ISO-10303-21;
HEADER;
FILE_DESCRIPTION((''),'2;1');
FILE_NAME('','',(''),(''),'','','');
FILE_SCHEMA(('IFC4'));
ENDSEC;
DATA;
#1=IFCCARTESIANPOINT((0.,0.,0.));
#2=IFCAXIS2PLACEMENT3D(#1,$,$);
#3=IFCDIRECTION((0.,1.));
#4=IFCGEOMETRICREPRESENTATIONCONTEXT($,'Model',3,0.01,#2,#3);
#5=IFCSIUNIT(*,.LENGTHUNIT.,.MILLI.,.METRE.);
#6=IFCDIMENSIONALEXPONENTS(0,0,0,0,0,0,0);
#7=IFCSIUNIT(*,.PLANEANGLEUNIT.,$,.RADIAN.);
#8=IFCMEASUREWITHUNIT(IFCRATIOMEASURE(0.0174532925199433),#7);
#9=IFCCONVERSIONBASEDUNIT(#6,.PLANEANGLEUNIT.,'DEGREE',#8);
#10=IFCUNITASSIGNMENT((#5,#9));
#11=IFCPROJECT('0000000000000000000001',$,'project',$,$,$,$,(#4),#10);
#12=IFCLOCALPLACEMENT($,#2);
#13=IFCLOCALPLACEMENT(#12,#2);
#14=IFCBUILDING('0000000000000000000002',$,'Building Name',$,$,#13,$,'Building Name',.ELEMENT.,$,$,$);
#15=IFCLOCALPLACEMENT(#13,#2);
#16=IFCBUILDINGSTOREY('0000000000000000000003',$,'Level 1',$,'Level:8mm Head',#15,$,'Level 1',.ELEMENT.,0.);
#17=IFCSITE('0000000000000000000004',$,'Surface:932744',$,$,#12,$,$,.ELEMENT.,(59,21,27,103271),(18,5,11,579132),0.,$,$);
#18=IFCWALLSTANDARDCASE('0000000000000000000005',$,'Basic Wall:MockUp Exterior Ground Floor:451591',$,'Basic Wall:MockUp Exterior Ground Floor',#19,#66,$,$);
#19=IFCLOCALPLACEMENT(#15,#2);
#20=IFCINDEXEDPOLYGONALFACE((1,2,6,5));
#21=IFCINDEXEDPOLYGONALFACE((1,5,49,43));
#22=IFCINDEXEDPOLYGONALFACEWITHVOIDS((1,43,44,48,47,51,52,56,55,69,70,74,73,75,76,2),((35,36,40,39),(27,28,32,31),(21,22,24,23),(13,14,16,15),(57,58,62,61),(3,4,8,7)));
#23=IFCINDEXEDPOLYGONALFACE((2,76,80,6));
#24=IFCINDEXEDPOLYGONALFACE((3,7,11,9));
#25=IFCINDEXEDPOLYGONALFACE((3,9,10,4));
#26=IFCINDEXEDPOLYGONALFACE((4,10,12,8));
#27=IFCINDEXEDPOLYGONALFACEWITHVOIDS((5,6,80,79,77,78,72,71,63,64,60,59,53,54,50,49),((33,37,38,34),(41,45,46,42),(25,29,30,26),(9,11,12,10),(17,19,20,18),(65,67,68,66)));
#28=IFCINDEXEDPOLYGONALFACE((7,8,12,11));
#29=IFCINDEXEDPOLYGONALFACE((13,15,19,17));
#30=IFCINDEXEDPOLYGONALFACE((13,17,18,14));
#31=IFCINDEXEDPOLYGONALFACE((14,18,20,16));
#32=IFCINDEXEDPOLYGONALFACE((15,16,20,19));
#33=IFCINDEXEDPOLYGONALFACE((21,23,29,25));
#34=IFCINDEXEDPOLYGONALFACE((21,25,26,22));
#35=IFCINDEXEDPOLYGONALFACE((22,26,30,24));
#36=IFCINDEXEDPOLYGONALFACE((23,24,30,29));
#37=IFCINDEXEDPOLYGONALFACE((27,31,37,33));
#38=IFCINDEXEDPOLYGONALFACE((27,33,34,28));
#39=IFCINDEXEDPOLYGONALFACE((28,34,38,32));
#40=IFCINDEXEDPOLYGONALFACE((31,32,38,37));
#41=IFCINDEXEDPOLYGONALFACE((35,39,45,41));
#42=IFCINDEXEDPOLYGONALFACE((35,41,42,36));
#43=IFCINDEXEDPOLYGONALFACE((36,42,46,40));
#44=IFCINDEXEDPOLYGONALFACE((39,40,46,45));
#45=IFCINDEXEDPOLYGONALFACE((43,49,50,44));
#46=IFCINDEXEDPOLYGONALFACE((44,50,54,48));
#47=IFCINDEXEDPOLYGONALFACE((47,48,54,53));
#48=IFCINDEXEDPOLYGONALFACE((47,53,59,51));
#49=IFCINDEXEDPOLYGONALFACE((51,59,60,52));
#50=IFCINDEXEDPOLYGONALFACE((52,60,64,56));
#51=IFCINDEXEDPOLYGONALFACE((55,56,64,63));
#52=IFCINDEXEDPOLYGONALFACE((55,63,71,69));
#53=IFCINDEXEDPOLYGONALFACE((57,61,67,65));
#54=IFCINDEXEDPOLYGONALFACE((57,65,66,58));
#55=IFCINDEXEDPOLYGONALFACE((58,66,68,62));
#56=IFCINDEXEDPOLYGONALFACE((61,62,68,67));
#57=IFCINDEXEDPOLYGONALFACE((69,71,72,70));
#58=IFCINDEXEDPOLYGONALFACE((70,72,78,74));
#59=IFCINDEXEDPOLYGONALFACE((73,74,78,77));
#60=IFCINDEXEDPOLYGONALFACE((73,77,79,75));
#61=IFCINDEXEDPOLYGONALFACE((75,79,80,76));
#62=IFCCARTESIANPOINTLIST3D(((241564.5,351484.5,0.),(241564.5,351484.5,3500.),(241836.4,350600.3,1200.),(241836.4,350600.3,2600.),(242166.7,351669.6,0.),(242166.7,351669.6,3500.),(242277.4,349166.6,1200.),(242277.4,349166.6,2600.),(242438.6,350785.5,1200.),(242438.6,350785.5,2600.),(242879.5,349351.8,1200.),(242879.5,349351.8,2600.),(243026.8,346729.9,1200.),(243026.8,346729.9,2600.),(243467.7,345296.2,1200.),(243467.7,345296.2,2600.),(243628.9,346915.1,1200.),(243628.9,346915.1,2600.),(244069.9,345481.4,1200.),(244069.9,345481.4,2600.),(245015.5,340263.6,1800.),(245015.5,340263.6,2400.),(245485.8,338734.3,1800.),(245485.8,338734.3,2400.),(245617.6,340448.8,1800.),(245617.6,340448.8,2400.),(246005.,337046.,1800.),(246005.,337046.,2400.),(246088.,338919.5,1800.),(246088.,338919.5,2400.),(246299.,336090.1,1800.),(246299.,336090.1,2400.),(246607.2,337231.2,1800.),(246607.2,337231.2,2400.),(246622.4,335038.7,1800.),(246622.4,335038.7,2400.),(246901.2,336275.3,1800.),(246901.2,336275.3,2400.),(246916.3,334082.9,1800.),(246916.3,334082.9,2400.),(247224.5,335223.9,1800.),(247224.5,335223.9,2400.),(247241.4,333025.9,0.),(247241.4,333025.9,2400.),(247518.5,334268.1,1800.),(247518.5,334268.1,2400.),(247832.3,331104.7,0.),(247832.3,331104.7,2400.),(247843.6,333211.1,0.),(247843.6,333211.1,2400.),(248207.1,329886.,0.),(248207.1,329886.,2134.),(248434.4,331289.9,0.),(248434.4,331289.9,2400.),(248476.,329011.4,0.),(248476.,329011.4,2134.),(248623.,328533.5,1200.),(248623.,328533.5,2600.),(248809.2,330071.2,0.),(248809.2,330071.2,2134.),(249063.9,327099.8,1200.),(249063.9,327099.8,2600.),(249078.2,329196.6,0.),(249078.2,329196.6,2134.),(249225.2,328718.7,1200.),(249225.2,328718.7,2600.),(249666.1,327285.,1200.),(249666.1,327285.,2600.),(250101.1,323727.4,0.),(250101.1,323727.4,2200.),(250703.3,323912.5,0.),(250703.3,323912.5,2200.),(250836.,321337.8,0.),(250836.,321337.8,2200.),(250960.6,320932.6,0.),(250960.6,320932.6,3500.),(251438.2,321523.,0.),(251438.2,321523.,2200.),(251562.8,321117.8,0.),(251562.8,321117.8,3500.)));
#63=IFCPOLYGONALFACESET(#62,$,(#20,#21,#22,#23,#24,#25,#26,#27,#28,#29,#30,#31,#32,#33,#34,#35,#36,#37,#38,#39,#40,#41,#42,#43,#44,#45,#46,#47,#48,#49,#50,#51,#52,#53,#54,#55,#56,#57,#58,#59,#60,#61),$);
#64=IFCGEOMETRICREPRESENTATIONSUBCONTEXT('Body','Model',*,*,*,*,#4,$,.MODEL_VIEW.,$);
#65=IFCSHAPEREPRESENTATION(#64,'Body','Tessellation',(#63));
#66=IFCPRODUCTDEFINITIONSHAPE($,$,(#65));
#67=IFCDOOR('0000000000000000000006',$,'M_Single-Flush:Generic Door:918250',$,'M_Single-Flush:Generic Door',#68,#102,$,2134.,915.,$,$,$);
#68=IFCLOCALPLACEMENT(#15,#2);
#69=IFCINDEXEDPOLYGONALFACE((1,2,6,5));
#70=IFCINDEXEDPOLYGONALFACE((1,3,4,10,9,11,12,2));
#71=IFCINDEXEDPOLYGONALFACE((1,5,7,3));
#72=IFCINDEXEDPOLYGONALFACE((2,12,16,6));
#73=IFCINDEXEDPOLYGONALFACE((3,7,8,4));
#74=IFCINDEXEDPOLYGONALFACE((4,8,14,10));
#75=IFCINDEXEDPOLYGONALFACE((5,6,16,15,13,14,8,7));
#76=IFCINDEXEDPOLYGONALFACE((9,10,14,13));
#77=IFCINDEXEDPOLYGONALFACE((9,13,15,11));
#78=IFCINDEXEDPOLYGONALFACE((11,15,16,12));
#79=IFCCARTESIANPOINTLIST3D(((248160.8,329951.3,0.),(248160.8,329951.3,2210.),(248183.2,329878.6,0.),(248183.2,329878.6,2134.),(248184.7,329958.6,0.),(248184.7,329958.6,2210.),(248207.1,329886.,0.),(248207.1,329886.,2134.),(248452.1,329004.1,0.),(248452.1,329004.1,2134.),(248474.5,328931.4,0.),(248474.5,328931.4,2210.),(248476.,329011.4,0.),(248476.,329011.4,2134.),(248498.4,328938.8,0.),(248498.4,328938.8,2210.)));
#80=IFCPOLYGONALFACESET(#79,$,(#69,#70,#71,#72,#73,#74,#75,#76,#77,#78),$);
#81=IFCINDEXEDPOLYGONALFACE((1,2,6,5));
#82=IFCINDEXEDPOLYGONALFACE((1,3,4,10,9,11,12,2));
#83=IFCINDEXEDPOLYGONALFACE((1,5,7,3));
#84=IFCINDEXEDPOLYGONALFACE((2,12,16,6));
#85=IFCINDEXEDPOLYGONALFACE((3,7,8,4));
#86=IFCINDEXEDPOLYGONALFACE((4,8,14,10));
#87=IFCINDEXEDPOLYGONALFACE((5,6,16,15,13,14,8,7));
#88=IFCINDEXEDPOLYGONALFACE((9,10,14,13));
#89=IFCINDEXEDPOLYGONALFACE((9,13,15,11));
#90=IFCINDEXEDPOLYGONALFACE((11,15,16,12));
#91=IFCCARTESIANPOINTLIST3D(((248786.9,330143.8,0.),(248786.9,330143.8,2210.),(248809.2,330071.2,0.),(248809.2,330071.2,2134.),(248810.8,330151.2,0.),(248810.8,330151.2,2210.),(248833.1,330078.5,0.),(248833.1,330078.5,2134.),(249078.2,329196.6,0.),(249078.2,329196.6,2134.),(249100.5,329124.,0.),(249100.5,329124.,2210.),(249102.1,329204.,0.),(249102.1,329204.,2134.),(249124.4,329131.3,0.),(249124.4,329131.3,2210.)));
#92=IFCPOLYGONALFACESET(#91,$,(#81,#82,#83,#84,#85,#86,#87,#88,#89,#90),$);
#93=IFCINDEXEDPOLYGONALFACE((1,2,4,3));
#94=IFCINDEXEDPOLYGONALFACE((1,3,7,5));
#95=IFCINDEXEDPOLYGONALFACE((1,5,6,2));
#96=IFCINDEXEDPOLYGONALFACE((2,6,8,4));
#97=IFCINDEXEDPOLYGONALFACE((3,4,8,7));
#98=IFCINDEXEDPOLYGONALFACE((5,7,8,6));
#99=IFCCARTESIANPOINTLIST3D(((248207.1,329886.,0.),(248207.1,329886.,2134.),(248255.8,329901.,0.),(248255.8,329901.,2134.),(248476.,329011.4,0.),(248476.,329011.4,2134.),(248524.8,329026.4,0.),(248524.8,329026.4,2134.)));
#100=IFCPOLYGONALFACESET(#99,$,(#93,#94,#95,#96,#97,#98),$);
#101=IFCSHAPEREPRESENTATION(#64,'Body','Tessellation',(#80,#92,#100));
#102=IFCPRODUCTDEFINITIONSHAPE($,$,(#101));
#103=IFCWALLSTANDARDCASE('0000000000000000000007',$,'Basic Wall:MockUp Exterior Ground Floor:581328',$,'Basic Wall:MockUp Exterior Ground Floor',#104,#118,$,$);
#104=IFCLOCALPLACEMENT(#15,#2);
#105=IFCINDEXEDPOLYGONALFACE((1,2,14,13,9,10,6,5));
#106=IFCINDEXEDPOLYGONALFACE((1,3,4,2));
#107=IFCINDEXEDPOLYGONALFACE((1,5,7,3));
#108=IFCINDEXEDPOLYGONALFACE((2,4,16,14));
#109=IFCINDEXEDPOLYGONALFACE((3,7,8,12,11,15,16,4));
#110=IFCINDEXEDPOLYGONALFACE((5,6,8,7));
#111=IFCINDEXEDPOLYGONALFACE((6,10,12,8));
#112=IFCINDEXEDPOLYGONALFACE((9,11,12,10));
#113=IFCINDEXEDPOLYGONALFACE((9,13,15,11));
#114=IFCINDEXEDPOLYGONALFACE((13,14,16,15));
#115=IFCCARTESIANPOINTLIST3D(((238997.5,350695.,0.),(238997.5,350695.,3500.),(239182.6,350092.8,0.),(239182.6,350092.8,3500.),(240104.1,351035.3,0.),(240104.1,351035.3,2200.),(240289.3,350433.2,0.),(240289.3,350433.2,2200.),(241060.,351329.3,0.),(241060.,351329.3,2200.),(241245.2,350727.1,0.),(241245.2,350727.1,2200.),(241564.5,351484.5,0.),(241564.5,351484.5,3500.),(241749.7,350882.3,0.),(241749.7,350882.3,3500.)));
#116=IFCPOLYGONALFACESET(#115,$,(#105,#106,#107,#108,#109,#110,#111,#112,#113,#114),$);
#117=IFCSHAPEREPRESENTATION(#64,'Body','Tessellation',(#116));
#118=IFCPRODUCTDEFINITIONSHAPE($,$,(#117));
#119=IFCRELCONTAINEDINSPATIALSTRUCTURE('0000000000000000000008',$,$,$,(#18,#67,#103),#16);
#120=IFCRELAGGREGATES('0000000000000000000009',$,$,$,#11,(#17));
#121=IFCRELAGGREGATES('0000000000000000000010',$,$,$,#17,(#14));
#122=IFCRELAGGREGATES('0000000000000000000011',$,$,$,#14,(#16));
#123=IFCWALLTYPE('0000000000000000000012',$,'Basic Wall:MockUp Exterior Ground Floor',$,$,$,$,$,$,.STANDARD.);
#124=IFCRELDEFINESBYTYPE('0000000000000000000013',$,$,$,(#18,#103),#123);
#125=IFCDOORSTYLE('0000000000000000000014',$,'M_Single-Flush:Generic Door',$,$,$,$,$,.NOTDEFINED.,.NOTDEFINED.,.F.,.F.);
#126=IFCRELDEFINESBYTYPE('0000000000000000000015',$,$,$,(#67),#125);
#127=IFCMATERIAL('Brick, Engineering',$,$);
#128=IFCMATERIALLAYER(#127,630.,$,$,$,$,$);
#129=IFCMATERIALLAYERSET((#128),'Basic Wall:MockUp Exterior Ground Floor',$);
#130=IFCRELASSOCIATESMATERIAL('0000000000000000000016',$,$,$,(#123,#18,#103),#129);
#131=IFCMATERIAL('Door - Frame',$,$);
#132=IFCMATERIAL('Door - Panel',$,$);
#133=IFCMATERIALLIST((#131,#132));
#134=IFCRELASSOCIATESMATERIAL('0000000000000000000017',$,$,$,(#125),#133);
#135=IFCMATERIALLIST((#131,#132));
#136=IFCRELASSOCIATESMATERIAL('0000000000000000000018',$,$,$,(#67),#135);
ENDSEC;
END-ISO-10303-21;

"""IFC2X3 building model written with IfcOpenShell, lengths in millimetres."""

from ifc_helpers import new_model, entity, si_unit, converted_unit, direction, frame, frame_2d, origin, place, context, subcontext, project, spatial, polyline, rectangle, outline, extrude, source, transform, mapped, material, material_list, layer, layer_set, layer_usage, type_object, type_shapes, element, fill, save


model = new_model("IFC2X3")

# Units and contexts
model_context = context("Model", 3, precision=0.01, world=origin(), true_north=direction((0.0, 1.0)))
body_context = subcontext(model_context, "Body", "Model", "MODEL_VIEW")
ifc_project = project(units=[si_unit("LENGTHUNIT", "METRE", prefix="MILLI"), converted_unit("PLANEANGLEUNIT", "DEGREE", entity("IfcRatioMeasure", 0.0174532925199433), si_unit("PLANEANGLEUNIT", "RADIAN"), dimensions=[0, 0, 0, 0, 0, 0, 0])], contexts=[model_context])

# Site, building, storey
site_placement = place(None, origin())
site = spatial("IfcSite", under=ifc_project, at=site_placement, Name="Surface:932744", CompositionType="ELEMENT", RefLatitude=(59, 21, 27, 103271), RefLongitude=(18, 5, 11, 579132), RefElevation=0.0)
building_placement = place(site_placement, origin())
building = spatial("IfcBuilding", under=site, at=building_placement, Name="Building Name", LongName="Building Name", CompositionType="ELEMENT")
storey_placement = place(building_placement, origin())
storey = spatial("IfcBuildingStorey", under=building, at=storey_placement, Name="Level 1", ObjectType="Level:8mm Head", LongName="Level 1", CompositionType="ELEMENT", Elevation=0.0)

# Wall, openings, door
ifc_material_1 = material(Name="Brick, Engineering")
ifc_layer_1 = layer(ifc_material_1, 630.0)
ifc_layer_set_1 = layer_set([ifc_layer_1], Name="Basic Wall:MockUp Exterior Ground Floor")
ifc_layer_usage_1 = layer_usage(ifc_layer_set_1, "AXIS2", "NEGATIVE", 315.0)
wall_type_1 = type_object("IfcWallType", Name="Basic Wall:MockUp Exterior Ground Floor", PredefinedType="STANDARD", material=ifc_layer_set_1)
wall_1_placement = place(building_placement, frame((241865.6, 351577.1, 0.0), z_axis=(0.0, 0.0, 1.0), x_axis=(0.293958, -0.955818, 0.0)))
wall_1 = element("IfcWallStandardCase", 1, at=wall_1_placement, inside=storey, type_object=wall_type_1, material=ifc_layer_usage_1, Name="Basic Wall:MockUp Exterior Ground Floor:451591", ObjectType="Basic Wall:MockUp Exterior Ground Floor", context=body_context, shape_type="SweptSolid", body=[
    extrude(rectangle(XDim=31964.1, YDim=630.0, at=frame_2d((15982.1, 0.0), x_axis=(-1.0, 0.0))), origin(), (0.0, 0.0, 1.0), 3500.0),
])
opening_1_placement = place(wall_1_placement, origin())
element("IfcOpeningElement", 2, at=opening_1_placement, cuts=wall_1, ObjectType="Opening", context=body_context, shape_type="SweptSolid", body=[
    extrude(rectangle(XDim=2134.0, YDim=220.0, at=frame_2d((0.0, 0.0), x_axis=(0.0, 1.0))), frame((11088.9, 3522.5, 4567.0), z_axis=(0.0, 1.0, 0.0), x_axis=(-1.0, 0.0, 0.0)), (0.0, 0.0, 1.0), 915.0),
])
opening_2_placement = place(wall_1_placement, origin())
element("IfcOpeningElement", 3, at=opening_2_placement, cuts=wall_1, ObjectType="Opening", context=body_context, shape_type="SweptSolid", body=[
    extrude(rectangle(XDim=2134.0, YDim=220.0, at=frame_2d((0.0, 0.0), x_axis=(0.0, 1.0))), frame((11088.9, 1308.8, 4567.0), z_axis=(0.0, 1.0, 0.0), x_axis=(1.0, 0.0, 0.0)), (0.0, 0.0, 1.0), 915.0),
])
opening_3_placement = place(wall_1_placement, frame((21321.8, 315.0, 0.0)))
element("IfcOpeningElement", 4, at=opening_3_placement, cuts=wall_1, ObjectType="Opening", context=body_context, shape_type="SweptSolid", body=[
    extrude(rectangle(XDim=2400.0, YDim=2010.0, at=frame_2d((1200.0, 1005.0), x_axis=(1.0, 0.0))), frame((0.0, 0.0, 0.0), z_axis=(0.0, -1.0, 0.0), x_axis=(0.0, 0.0, 1.0)), (0.0, 0.0, 1.0), 630.0),
])
opening_4_placement = place(wall_1_placement, frame((29040.1, -315.0, 0.0)))
element("IfcOpeningElement", 5, at=opening_4_placement, cuts=wall_1, ObjectType="Opening", context=body_context, shape_type="SweptSolid", body=[
    extrude(rectangle(XDim=2200.0, YDim=2500.0, at=frame_2d((1100.0, 1250.0), x_axis=(1.0, 0.0))), frame((0.0, 0.0, 0.0), z_axis=(0.0, 1.0, 0.0), x_axis=(0.0, 0.0, 1.0)), (0.0, 0.0, 1.0), 630.0),
])
opening_5_placement = place(wall_1_placement, frame((23511.8, 315.0, 0.0)))
opening_5 = element("IfcOpeningElement", 6, at=opening_5_placement, cuts=wall_1, ObjectType="Opening", context=body_context, shape_type="SweptSolid", body=[
    extrude(rectangle(XDim=915.0, YDim=2134.0, at=frame_2d((1067.0, 457.5), x_axis=(0.0, 1.0))), frame((0.0, 0.0, 0.0), z_axis=(0.0, -1.0, 0.0), x_axis=(0.0, 0.0, 1.0)), (0.0, 0.0, 1.0), 630.0),
])
opening_6_placement = place(wall_1_placement, frame((4974.3, -315.0, 1200.0)))
element("IfcOpeningElement", 7, at=opening_6_placement, cuts=wall_1, ObjectType="Opening", context=body_context, shape_type="SweptSolid", body=[
    extrude(rectangle(XDim=1400.0, YDim=1500.0, at=frame_2d((700.0, 750.0), x_axis=(1.0, 0.0))), frame((0.0, 0.0, 0.0), z_axis=(0.0, 1.0, 0.0), x_axis=(0.0, 0.0, 1.0)), (0.0, 0.0, 1.0), 630.0),
])
opening_7_placement = place(wall_1_placement, frame((925.0, -315.0, 1200.0)))
element("IfcOpeningElement", 8, at=opening_7_placement, cuts=wall_1, ObjectType="Opening", context=body_context, shape_type="SweptSolid", body=[
    extrude(rectangle(XDim=1400.0, YDim=1500.0, at=frame_2d((700.0, 750.0), x_axis=(1.0, 0.0))), frame((0.0, 0.0, 0.0), z_axis=(0.0, 1.0, 0.0), x_axis=(0.0, 0.0, 1.0)), (0.0, 0.0, 1.0), 630.0),
])
opening_8_placement = place(wall_1_placement, frame((15105.9, -315.0, 1800.0)))
element("IfcOpeningElement", 9, at=opening_8_placement, cuts=wall_1, ObjectType="Opening", context=body_context, shape_type="SweptSolid", body=[
    extrude(rectangle(XDim=600.0, YDim=1000.0, at=frame_2d((300.0, 500.0), x_axis=(1.0, 0.0))), frame((0.0, 0.0, 0.0), z_axis=(0.0, 1.0, 0.0), x_axis=(0.0, 0.0, 1.0)), (0.0, 0.0, 1.0), 630.0),
])
opening_9_placement = place(wall_1_placement, frame((11739.5, -315.0, 1800.0)))
element("IfcOpeningElement", 10, at=opening_9_placement, cuts=wall_1, ObjectType="Opening", context=body_context, shape_type="SweptSolid", body=[
    extrude(rectangle(XDim=600.0, YDim=1600.0, at=frame_2d((300.0, 800.0), x_axis=(1.0, 0.0))), frame((0.0, 0.0, 0.0), z_axis=(0.0, 1.0, 0.0), x_axis=(0.0, 0.0, 1.0)), (0.0, 0.0, 1.0), 630.0),
])
opening_10_placement = place(wall_1_placement, frame((17205.9, -315.0, 1800.0)))
element("IfcOpeningElement", 11, at=opening_10_placement, cuts=wall_1, ObjectType="Opening", context=body_context, shape_type="SweptSolid", body=[
    extrude(rectangle(XDim=600.0, YDim=1000.0, at=frame_2d((300.0, 500.0), x_axis=(1.0, 0.0))), frame((0.0, 0.0, 0.0), z_axis=(0.0, 1.0, 0.0), x_axis=(0.0, 0.0, 1.0)), (0.0, 0.0, 1.0), 630.0),
])
opening_11_placement = place(wall_1_placement, frame((24011.8, -315.0, 1200.0)))
element("IfcOpeningElement", 12, at=opening_11_placement, cuts=wall_1, ObjectType="Opening", context=body_context, shape_type="SweptSolid", body=[
    extrude(rectangle(XDim=1400.0, YDim=1500.0, at=frame_2d((700.0, 750.0), x_axis=(1.0, 0.0))), frame((0.0, 0.0, 0.0), z_axis=(0.0, 1.0, 0.0), x_axis=(0.0, 0.0, 1.0)), (0.0, 0.0, 1.0), 630.0),
])
ifc_material_2 = material(Name="Door - Frame")
ifc_material_3 = material(Name="Door - Panel")
ifc_material_list_1 = material_list([ifc_material_2, ifc_material_3])
ifc_material_list_2 = material_list([ifc_material_2, ifc_material_3])
door_style_1 = type_object("IfcDoorStyle", Name="M_Single-Flush:Generic Door", ConstructionType="NOTDEFINED", OperationType="NOTDEFINED", ParameterTakesPrecedence=False, Sizeable=False, material=ifc_material_list_2)
shared_shape_1 = source(origin(), body_context, "Body", "SweptSolid", [
    extrude(outline(polyline([(-533.5, -1124.0), (533.5, -1124.0), (533.5, 1086.0), (457.5, 1086.0), (457.5, -1048.0), (-457.5, -1048.0), (-457.5, 1086.0), (-533.5, 1086.0), (-533.5, -1124.0)])), frame((457.5, 630.0, 1086.0), z_axis=(0.0, 1.0, 0.0), x_axis=(1.0, 0.0, 0.0)), (0.0, 0.0, 1.0), 25.0),
    extrude(outline(polyline([(-1124.0, -533.5), (1086.0, -533.5), (1086.0, -457.5), (-1048.0, -457.5), (-1048.0, 457.5), (1086.0, 457.5), (1086.0, 533.5), (-1124.0, 533.5), (-1124.0, -533.5)])), frame((457.5, -25.0, 1086.0), z_axis=(0.0, 1.0, 0.0), x_axis=(0.0, 0.0, -1.0)), (0.0, 0.0, 1.0), 25.0),
    extrude(rectangle(XDim=51.0, YDim=915.0, at=frame_2d((0.0, 0.0), x_axis=(1.0, 0.0))), frame((457.5, 604.5, 0.0), z_axis=(0.0, 0.0, 1.0), x_axis=(0.0, 1.0, 0.0)), (0.0, 0.0, 1.0), 2134.0),
])
type_shapes(door_style_1, [shared_shape_1])
door_1_placement = place(opening_5_placement, frame((0.0, 0.0, 0.0), z_axis=(0.0, 0.0, 1.0), x_axis=(-1.0, 0.0, 0.0)))
door_1 = element("IfcDoor", 13, at=door_1_placement, inside=storey, type_object=door_style_1, material=ifc_material_list_1, Name="M_Single-Flush:Generic Door:918250", ObjectType="M_Single-Flush:Generic Door", OverallHeight=2134.0, OverallWidth=915.0, context=body_context, shape_type="MappedRepresentation", body=[
    mapped(shared_shape_1, transform((0.0, 0.0, 0.0), scale=1.0)),
])
fill(opening_5, door_1)

# Wall, opening
ifc_layer_usage_2 = layer_usage(ifc_layer_set_1, "AXIS2", "NEGATIVE", 315.0)
wall_2_placement = place(building_placement, frame((241657.1, 351183.4, 0.0), z_axis=(0.0, 0.0, 1.0), x_axis=(-0.955818, -0.293958, 0.0)))
wall_2 = element("IfcWallStandardCase", 14, at=wall_2_placement, inside=storey, type_object=wall_type_1, material=ifc_layer_usage_2, Name="Basic Wall:MockUp Exterior Ground Floor:581328", ObjectType="Basic Wall:MockUp Exterior Ground Floor", context=body_context, shape_type="SweptSolid", body=[
    extrude(rectangle(XDim=2685.7, YDim=630.0, at=frame_2d((1342.9, 0.0), x_axis=(-1.0, 0.0))), origin(), (0.0, 0.0, 1.0), 3500.0),
])
opening_12_placement = place(wall_2_placement, frame((1527.9, 315.0, 0.0)))
element("IfcOpeningElement", 15, at=opening_12_placement, cuts=wall_2, ObjectType="Opening", context=body_context, shape_type="SweptSolid", body=[
    extrude(rectangle(XDim=2200.0, YDim=1000.0, at=frame_2d((1100.0, 500.0), x_axis=(1.0, 0.0))), frame((0.0, 0.0, 0.0), z_axis=(0.0, -1.0, 0.0), x_axis=(0.0, 0.0, 1.0)), (0.0, 0.0, 1.0), 630.0),
])

save(model, "model.ifc")
